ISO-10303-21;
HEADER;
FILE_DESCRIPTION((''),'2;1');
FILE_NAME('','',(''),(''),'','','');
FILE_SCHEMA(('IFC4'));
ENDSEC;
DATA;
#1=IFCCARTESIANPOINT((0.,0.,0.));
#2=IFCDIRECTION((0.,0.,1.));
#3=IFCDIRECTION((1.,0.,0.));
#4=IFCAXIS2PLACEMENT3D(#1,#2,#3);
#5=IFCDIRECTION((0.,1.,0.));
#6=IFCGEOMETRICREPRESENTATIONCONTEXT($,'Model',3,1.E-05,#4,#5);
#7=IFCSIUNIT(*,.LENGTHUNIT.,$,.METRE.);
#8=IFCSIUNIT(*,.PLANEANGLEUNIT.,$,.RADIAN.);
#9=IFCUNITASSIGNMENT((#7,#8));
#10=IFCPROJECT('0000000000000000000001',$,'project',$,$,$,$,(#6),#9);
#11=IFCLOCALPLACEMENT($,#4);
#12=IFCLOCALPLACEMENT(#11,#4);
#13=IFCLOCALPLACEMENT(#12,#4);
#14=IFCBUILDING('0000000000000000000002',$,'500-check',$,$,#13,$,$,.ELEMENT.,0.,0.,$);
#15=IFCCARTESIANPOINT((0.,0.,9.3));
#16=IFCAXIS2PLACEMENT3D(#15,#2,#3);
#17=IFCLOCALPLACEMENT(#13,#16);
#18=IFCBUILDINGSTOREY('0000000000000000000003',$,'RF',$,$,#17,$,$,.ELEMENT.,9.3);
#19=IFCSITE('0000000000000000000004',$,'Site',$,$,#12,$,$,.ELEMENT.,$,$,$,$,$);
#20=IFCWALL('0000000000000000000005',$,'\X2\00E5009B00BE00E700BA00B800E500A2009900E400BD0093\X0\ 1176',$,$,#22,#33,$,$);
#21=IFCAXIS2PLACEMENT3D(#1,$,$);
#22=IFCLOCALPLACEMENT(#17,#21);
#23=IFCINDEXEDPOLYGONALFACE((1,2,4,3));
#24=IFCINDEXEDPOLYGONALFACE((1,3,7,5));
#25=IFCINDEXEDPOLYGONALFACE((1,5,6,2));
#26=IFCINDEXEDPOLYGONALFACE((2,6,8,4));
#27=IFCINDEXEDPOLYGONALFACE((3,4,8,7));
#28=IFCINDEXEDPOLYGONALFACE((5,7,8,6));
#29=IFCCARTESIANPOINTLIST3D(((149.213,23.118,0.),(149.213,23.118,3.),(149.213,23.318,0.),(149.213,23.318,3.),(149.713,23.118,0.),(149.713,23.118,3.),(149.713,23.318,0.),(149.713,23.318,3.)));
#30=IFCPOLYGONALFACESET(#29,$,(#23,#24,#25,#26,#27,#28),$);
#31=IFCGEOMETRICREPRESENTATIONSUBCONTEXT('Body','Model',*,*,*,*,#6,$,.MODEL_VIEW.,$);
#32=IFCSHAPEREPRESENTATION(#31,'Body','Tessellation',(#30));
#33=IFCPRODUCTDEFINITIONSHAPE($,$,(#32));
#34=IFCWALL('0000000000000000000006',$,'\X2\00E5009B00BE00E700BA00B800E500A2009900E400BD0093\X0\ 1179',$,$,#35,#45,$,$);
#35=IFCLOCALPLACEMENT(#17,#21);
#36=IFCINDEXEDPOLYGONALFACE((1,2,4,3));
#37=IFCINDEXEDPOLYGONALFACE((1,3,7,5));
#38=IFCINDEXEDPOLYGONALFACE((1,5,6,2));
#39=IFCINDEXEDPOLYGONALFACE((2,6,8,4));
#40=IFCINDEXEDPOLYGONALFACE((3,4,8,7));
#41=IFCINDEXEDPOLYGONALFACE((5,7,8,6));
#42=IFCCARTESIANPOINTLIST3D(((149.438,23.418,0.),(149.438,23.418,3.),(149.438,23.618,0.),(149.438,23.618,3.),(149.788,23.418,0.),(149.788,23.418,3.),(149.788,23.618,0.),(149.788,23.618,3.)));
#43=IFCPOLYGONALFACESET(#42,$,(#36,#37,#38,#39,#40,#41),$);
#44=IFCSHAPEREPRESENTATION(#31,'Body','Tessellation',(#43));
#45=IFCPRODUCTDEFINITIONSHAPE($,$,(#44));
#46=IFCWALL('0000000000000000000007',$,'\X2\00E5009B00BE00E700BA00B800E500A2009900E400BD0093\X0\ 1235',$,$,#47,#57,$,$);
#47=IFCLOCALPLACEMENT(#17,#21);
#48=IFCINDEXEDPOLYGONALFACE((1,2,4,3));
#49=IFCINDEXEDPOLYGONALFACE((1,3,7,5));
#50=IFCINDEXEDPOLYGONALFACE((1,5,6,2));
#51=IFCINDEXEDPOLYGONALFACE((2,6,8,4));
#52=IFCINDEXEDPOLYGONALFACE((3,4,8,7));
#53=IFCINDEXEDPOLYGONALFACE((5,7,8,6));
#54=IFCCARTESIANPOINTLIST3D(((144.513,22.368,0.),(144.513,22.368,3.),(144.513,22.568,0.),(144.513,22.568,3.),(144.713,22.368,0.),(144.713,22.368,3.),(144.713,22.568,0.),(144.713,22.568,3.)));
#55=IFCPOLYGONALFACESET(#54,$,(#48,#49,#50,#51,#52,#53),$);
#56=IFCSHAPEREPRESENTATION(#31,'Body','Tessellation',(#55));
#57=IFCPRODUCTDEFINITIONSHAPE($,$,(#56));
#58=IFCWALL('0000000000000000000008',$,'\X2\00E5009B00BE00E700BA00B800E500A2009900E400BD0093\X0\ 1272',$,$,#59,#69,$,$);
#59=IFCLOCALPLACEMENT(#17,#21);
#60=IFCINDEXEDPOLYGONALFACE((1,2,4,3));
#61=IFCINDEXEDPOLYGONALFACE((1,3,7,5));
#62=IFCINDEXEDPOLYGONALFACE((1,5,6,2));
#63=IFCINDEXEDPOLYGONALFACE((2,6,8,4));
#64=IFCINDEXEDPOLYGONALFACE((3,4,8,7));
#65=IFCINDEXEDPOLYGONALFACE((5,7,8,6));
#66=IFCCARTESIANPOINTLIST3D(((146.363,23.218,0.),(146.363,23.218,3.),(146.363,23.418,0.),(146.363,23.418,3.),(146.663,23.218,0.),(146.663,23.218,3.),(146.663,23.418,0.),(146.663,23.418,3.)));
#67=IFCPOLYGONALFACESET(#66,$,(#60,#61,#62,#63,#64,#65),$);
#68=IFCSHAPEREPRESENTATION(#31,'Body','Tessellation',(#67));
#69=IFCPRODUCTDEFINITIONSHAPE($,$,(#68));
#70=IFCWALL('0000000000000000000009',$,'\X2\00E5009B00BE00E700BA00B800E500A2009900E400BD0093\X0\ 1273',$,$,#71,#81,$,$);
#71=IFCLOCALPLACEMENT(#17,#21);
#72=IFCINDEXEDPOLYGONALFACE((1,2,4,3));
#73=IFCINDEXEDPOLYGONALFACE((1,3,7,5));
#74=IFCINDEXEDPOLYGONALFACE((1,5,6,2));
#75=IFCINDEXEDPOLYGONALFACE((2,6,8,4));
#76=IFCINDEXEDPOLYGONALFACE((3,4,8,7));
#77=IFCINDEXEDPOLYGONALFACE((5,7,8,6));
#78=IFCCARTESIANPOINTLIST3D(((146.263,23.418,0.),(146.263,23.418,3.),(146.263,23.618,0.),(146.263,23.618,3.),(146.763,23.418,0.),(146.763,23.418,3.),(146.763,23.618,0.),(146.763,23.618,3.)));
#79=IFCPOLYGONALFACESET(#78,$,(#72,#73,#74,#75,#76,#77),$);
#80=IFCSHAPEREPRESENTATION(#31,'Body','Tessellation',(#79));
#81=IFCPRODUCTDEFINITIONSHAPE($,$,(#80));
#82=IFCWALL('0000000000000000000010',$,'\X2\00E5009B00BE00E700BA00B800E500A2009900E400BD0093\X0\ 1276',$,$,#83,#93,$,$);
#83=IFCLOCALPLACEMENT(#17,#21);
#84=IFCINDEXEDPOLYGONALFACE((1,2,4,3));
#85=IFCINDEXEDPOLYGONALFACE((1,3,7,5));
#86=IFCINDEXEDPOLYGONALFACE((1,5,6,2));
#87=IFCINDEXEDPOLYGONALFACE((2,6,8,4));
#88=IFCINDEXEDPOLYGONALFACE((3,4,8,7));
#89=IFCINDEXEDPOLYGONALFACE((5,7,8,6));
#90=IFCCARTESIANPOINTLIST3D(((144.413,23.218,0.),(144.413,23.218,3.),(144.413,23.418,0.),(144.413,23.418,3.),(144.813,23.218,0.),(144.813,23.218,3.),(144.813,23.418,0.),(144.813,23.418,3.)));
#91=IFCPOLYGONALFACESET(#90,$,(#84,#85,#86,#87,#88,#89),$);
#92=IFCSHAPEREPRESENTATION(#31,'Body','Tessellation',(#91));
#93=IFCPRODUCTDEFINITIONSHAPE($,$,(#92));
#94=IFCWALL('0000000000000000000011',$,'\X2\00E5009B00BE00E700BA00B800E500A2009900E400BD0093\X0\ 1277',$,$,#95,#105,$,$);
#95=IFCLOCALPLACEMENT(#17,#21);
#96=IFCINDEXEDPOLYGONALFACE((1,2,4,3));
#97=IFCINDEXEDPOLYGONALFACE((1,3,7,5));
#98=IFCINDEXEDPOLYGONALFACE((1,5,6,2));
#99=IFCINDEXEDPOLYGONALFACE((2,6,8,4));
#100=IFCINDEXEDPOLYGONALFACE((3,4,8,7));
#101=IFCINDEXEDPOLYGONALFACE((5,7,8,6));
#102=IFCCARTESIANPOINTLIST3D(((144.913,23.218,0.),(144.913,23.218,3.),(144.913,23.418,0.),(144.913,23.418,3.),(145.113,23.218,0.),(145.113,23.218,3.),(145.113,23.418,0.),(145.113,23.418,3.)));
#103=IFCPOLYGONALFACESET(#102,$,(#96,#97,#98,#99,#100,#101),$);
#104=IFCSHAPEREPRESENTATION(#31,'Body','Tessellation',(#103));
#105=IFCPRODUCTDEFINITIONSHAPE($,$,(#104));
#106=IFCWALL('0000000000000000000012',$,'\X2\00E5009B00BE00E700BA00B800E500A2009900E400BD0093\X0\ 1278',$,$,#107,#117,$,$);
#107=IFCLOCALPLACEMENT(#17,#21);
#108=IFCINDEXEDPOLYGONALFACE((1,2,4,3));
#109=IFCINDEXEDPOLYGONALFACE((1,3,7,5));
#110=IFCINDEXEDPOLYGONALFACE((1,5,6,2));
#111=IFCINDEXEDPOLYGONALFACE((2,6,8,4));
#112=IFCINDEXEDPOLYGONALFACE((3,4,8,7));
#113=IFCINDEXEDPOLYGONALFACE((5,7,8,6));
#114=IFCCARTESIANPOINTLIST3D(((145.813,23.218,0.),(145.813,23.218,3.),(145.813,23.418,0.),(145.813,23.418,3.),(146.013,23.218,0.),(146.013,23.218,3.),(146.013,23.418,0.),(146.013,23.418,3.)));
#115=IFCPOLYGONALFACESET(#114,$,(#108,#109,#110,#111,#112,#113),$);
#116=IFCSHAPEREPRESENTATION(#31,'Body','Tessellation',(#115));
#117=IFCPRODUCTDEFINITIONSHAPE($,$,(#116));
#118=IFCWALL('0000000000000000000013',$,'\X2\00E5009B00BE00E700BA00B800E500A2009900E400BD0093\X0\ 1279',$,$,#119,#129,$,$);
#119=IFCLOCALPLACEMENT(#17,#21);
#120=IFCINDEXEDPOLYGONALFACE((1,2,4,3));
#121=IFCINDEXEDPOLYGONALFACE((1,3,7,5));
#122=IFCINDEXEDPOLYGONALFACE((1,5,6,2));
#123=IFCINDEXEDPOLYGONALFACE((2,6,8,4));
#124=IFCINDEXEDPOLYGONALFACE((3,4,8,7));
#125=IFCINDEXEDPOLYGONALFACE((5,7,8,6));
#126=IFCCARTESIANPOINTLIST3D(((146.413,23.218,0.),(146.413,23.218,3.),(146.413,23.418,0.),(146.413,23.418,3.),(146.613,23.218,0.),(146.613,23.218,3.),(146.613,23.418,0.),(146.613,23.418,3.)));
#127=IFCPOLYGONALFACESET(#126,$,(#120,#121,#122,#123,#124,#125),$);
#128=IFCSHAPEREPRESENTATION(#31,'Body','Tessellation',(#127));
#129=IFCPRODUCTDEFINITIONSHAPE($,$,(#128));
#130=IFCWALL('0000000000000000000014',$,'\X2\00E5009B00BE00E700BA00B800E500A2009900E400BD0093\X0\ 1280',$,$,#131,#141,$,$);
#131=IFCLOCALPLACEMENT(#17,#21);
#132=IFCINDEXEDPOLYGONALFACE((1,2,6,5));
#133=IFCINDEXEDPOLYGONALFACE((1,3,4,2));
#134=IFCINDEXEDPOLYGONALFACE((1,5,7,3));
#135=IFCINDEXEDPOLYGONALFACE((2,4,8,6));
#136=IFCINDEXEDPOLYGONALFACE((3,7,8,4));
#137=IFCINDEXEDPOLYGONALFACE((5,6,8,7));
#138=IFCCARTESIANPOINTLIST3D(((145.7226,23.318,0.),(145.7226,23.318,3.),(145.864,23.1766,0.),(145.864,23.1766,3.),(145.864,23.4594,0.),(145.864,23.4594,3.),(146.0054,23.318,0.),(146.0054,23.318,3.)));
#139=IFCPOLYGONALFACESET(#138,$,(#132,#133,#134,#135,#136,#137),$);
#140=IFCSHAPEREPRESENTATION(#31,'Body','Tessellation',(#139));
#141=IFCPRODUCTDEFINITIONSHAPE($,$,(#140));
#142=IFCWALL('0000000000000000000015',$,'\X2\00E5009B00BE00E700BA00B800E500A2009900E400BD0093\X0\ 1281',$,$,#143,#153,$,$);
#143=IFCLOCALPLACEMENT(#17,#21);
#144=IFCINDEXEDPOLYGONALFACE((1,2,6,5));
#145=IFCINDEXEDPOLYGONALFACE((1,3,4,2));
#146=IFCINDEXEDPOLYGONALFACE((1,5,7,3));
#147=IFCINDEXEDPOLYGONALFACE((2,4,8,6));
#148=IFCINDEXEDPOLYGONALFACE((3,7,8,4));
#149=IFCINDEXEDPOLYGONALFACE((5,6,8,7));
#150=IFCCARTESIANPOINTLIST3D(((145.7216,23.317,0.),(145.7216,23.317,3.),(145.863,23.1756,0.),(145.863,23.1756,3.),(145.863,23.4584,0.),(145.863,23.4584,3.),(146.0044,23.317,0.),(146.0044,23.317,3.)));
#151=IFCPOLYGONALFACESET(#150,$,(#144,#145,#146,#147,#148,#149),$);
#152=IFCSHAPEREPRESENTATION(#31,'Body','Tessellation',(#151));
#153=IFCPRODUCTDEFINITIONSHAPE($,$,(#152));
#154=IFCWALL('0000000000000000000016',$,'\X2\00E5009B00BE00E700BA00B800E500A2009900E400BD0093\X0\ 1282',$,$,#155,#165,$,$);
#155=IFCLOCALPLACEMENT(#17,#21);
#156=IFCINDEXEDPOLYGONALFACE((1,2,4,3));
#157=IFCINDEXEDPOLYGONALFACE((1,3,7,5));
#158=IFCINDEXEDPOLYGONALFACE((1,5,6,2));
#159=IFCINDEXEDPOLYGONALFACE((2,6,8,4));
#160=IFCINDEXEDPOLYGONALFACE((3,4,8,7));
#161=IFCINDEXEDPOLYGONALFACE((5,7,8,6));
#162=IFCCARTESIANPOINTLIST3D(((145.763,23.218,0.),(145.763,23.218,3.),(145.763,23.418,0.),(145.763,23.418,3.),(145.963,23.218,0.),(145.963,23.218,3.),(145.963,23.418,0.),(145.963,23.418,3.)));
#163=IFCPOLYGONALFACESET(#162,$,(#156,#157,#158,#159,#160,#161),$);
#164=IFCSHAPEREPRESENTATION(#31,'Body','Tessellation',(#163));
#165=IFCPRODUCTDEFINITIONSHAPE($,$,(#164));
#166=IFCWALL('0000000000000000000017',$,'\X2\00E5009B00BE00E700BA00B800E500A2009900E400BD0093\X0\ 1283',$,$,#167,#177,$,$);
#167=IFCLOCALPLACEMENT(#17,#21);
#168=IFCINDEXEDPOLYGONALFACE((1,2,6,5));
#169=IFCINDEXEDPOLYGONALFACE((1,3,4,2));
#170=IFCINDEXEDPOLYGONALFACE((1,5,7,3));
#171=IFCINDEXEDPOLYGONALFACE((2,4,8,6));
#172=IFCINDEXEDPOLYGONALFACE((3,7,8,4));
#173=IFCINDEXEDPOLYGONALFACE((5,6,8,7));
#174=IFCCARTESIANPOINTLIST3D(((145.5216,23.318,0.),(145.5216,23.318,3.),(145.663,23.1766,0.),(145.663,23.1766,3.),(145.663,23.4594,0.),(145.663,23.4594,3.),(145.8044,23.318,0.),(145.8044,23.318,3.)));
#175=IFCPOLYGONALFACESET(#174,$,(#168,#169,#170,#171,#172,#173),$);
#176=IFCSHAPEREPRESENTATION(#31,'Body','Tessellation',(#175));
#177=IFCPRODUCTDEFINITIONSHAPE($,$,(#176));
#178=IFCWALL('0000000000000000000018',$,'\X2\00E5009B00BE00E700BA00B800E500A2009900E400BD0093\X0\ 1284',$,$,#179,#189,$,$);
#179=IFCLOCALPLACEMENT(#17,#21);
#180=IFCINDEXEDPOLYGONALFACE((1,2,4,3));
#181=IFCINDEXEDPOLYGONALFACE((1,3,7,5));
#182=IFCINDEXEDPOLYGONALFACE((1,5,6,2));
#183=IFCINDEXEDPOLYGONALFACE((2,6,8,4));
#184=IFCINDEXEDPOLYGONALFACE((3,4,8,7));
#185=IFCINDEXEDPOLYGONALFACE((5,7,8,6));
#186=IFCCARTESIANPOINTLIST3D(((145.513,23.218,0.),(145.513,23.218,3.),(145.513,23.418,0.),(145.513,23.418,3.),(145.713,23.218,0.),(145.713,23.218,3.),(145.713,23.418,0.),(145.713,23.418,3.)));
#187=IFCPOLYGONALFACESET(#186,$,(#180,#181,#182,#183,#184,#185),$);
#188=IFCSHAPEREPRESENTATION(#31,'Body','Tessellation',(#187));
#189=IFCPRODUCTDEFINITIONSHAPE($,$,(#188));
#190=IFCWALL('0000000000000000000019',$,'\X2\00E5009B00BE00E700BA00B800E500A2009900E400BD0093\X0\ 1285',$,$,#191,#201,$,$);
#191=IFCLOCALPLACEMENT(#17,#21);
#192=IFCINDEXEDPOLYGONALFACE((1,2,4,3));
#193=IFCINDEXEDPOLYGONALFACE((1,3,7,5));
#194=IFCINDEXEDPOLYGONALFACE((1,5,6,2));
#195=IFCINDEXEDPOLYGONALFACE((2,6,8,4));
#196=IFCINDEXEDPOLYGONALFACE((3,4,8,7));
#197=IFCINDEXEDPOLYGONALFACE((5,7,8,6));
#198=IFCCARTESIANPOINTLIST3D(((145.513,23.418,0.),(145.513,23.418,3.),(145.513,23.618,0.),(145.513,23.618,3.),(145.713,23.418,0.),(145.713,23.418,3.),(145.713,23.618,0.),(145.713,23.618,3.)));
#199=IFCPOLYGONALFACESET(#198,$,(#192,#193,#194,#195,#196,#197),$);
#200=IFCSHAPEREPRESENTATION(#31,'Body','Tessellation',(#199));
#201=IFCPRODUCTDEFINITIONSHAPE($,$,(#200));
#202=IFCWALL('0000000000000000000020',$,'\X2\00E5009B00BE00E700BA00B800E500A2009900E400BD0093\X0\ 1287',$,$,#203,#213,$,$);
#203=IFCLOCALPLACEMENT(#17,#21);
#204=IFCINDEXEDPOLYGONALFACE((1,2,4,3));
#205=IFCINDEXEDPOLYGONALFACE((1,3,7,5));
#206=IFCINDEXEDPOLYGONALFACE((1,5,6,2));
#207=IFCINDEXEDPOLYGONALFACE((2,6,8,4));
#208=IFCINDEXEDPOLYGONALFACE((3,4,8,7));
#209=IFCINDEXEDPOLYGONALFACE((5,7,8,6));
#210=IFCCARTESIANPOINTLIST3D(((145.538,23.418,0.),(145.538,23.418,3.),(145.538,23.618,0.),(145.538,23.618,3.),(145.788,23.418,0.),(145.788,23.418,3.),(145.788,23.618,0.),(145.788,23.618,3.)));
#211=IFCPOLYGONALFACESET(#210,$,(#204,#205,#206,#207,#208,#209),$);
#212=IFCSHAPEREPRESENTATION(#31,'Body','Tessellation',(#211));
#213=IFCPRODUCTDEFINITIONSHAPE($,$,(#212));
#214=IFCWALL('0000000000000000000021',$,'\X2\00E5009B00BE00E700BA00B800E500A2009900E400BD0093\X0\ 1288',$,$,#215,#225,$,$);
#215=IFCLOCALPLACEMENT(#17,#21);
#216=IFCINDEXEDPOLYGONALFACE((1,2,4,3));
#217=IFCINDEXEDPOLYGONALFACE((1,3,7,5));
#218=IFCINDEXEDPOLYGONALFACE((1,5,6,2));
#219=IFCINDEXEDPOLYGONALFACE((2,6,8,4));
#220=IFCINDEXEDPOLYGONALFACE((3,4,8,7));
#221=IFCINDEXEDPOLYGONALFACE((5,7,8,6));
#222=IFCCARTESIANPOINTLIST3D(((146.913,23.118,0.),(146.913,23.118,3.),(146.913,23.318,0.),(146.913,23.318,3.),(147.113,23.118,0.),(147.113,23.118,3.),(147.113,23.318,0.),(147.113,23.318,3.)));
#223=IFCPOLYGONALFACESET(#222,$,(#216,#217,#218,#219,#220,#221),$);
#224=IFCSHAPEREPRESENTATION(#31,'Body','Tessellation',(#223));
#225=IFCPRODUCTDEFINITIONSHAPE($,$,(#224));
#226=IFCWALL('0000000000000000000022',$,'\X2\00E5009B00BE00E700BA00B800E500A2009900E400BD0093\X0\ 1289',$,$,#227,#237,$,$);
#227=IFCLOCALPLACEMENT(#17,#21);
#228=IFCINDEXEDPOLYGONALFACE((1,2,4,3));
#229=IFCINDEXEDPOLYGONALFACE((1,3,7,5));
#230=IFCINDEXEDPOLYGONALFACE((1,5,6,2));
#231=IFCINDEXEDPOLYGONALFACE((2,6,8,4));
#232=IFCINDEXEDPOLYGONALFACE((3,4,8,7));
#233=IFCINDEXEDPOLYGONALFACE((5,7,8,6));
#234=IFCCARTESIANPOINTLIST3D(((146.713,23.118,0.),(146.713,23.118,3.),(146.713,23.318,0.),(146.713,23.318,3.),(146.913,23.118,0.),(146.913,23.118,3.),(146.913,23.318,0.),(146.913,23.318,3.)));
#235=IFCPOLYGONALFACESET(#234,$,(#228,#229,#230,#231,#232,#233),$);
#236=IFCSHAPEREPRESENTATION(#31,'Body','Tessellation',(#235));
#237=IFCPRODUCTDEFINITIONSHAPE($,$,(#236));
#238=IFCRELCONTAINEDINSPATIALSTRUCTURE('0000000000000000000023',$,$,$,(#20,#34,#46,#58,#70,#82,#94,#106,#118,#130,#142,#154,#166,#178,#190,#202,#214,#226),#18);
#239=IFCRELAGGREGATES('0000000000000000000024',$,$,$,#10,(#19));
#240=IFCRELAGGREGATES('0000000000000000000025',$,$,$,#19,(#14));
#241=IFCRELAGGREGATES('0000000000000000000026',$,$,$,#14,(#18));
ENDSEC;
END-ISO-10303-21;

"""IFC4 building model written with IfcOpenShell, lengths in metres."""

from ifc_helpers import new_model, si_unit, direction, frame, frame_2d, origin_with_axes, place, context, subcontext, project, spatial, rectangle, extrude, element, save


model = new_model("IFC4")

# Units and contexts
model_context = context("Model", 3, precision=1e-05, world=origin_with_axes(), true_north=direction((0.0, 1.0, 0.0)))
body_context = subcontext(model_context, "Body", "Model", "MODEL_VIEW")
ifc_project = project(units=[si_unit("LENGTHUNIT", "METRE"), si_unit("PLANEANGLEUNIT", "RADIAN")], contexts=[model_context])

# Site, building, storey
placement = place(None, origin_with_axes())
site_placement = place(placement, origin_with_axes())
site = spatial("IfcSite", under=ifc_project, at=site_placement, Name="Site", CompositionType="ELEMENT")
building_placement = place(site_placement, origin_with_axes())
building = spatial("IfcBuilding", under=site, at=building_placement, Name="500-check", CompositionType="ELEMENT", ElevationOfRefHeight=0.0, ElevationOfTerrain=0.0)
storey_placement = place(building_placement, frame((0.0, 0.0, 9.3), z_axis=(0.0, 0.0, 1.0), x_axis=(1.0, 0.0, 0.0)))
storey = spatial("IfcBuildingStorey", under=building, at=storey_placement, Name="RF", CompositionType="ELEMENT", Elevation=9.3)

# Walls
wall_1_placement = place(storey_placement, frame((149.463, 23.218, 0.0), z_axis=(0.0, 0.0, 1.0), x_axis=(1.0, 0.0, 0.0)))
element("IfcWall", 1, at=wall_1_placement, inside=storey, Name="å\u009b¾çº¸å¢\u0099ä½\u0093 1176", context=body_context, shape_type="SweptSolid", body=[
    extrude(rectangle(XDim=0.5, YDim=0.2, at=frame_2d((0.0, 0.0), x_axis=(1.0, 0.0, 0.0))), frame((0.0, 0.0, 0.0), z_axis=(0.0, 0.0, 1.0)), (0.0, 0.0, 1.0), 3.0),
])
wall_2_placement = place(storey_placement, frame((149.613, 23.518, 0.0), z_axis=(0.0, 0.0, 1.0), x_axis=(1.0, 0.0, 0.0)))
element("IfcWall", 2, at=wall_2_placement, inside=storey, Name="å\u009b¾çº¸å¢\u0099ä½\u0093 1179", context=body_context, shape_type="SweptSolid", body=[
    extrude(rectangle(XDim=0.35, YDim=0.2, at=frame_2d((0.0, 0.0), x_axis=(1.0, 0.0, 0.0))), frame((0.0, 0.0, 0.0), z_axis=(0.0, 0.0, 1.0)), (0.0, 0.0, 1.0), 3.0),
])
wall_3_placement = place(storey_placement, frame((144.613, 22.468, 0.0), z_axis=(0.0, 0.0, 1.0), x_axis=(-1.0, 0.0, 0.0)))
element("IfcWall", 3, at=wall_3_placement, inside=storey, Name="å\u009b¾çº¸å¢\u0099ä½\u0093 1235", context=body_context, shape_type="SweptSolid", body=[
    extrude(rectangle(XDim=0.2, YDim=0.2, at=frame_2d((0.0, 0.0), x_axis=(1.0, 0.0, 0.0))), frame((0.0, 0.0, 0.0), z_axis=(0.0, 0.0, 1.0)), (0.0, 0.0, 1.0), 3.0),
])
wall_4_placement = place(storey_placement, frame((146.513, 23.318, 0.0), z_axis=(0.0, 0.0, 1.0), x_axis=(1.0, 0.0, 0.0)))
element("IfcWall", 4, at=wall_4_placement, inside=storey, Name="å\u009b¾çº¸å¢\u0099ä½\u0093 1272", context=body_context, shape_type="SweptSolid", body=[
    extrude(rectangle(XDim=0.3, YDim=0.2, at=frame_2d((0.0, 0.0), x_axis=(1.0, 0.0, 0.0))), frame((0.0, 0.0, 0.0), z_axis=(0.0, 0.0, 1.0)), (0.0, 0.0, 1.0), 3.0),
])
wall_5_placement = place(storey_placement, frame((146.513, 23.518, 0.0), z_axis=(0.0, 0.0, 1.0), x_axis=(1.0, 0.0, 0.0)))
element("IfcWall", 5, at=wall_5_placement, inside=storey, Name="å\u009b¾çº¸å¢\u0099ä½\u0093 1273", context=body_context, shape_type="SweptSolid", body=[
    extrude(rectangle(XDim=0.5, YDim=0.2, at=frame_2d((0.0, 0.0), x_axis=(1.0, 0.0, 0.0))), frame((0.0, 0.0, 0.0), z_axis=(0.0, 0.0, 1.0)), (0.0, 0.0, 1.0), 3.0),
])
wall_6_placement = place(storey_placement, frame((144.613, 23.318, 0.0), z_axis=(0.0, 0.0, 1.0), x_axis=(1.0, 0.0, 0.0)))
element("IfcWall", 6, at=wall_6_placement, inside=storey, Name="å\u009b¾çº¸å¢\u0099ä½\u0093 1276", context=body_context, shape_type="SweptSolid", body=[
    extrude(rectangle(XDim=0.4, YDim=0.2, at=frame_2d((0.0, 0.0), x_axis=(1.0, 0.0, 0.0))), frame((0.0, 0.0, 0.0), z_axis=(0.0, 0.0, 1.0)), (0.0, 0.0, 1.0), 3.0),
])
for number, where, z_axis, x_axis, name in (
    (7, (145.013, 23.318, 0.0), (0.0, 0.0, 1.0), (0.0, 1.0, 0.0), "å\u009b¾çº¸å¢\u0099ä½\u0093 1277"),
    (8, (145.913, 23.318, 0.0), (0.0, 0.0, 1.0), (0.0, 1.0, 0.0), "å\u009b¾çº¸å¢\u0099ä½\u0093 1278"),
    (9, (146.513, 23.318, 0.0), (0.0, 0.0, 1.0), (0.0, 1.0, 0.0), "å\u009b¾çº¸å¢\u0099ä½\u0093 1279"),
    (10, (145.864, 23.318, 0.0), (0.0, 0.0, 1.0), (-0.707107, -0.707107, 0.0), "å\u009b¾çº¸å¢\u0099ä½\u0093 1280"),
    (11, (145.863, 23.317, 0.0), (0.0, 0.0, 1.0), (0.707107, 0.707107, 0.0), "å\u009b¾çº¸å¢\u0099ä½\u0093 1281"),
    (12, (145.863, 23.318, 0.0), (0.0, 0.0, 1.0), (1.0, 0.0, 0.0), "å\u009b¾çº¸å¢\u0099ä½\u0093 1282"),
    (13, (145.663, 23.318, 0.0), (0.0, 0.0, 1.0), (0.707107, -0.707107, 0.0), "å\u009b¾çº¸å¢\u0099ä½\u0093 1283"),
    (14, (145.613, 23.318, 0.0), (0.0, 0.0, 1.0), (1.0, 0.0, 0.0), "å\u009b¾çº¸å¢\u0099ä½\u0093 1284"),
    (15, (145.613, 23.518, 0.0), (0.0, 0.0, 1.0), (1.0, 0.0, 0.0), "å\u009b¾çº¸å¢\u0099ä½\u0093 1285"),
):
    element("IfcWall", number, at=place(storey_placement, frame(where, z_axis=z_axis, x_axis=x_axis)), inside=storey, Name=name, context=body_context, shape_type="SweptSolid", body=[
        extrude(rectangle(XDim=0.2, YDim=0.2, at=frame_2d((0.0, 0.0), x_axis=(1.0, 0.0, 0.0))), frame((0.0, 0.0, 0.0), z_axis=(0.0, 0.0, 1.0)), (0.0, 0.0, 1.0), 3.0),
    ])
wall_7_placement = place(storey_placement, frame((145.663, 23.518, 0.0), z_axis=(0.0, 0.0, 1.0), x_axis=(1.0, 0.0, 0.0)))
element("IfcWall", 16, at=wall_7_placement, inside=storey, Name="å\u009b¾çº¸å¢\u0099ä½\u0093 1287", context=body_context, shape_type="SweptSolid", body=[
    extrude(rectangle(XDim=0.25, YDim=0.2, at=frame_2d((0.0, 0.0), x_axis=(1.0, 0.0, 0.0))), frame((0.0, 0.0, 0.0), z_axis=(0.0, 0.0, 1.0)), (0.0, 0.0, 1.0), 3.0),
])
for number, where, z_axis, x_axis, name in (
    (17, (147.013, 23.218, 0.0), (0.0, 0.0, 1.0), (-1.0, 0.0, 0.0), "å\u009b¾çº¸å¢\u0099ä½\u0093 1288"),
    (18, (146.813, 23.218, 0.0), (0.0, 0.0, 1.0), (0.0, 1.0, 0.0), "å\u009b¾çº¸å¢\u0099ä½\u0093 1289"),
):
    element("IfcWall", number, at=place(storey_placement, frame(where, z_axis=z_axis, x_axis=x_axis)), inside=storey, Name=name, context=body_context, shape_type="SweptSolid", body=[
        extrude(rectangle(XDim=0.2, YDim=0.2, at=frame_2d((0.0, 0.0), x_axis=(1.0, 0.0, 0.0))), frame((0.0, 0.0, 0.0), z_axis=(0.0, 0.0, 1.0)), (0.0, 0.0, 1.0), 3.0),
    ])

save(model, "model.ifc")
